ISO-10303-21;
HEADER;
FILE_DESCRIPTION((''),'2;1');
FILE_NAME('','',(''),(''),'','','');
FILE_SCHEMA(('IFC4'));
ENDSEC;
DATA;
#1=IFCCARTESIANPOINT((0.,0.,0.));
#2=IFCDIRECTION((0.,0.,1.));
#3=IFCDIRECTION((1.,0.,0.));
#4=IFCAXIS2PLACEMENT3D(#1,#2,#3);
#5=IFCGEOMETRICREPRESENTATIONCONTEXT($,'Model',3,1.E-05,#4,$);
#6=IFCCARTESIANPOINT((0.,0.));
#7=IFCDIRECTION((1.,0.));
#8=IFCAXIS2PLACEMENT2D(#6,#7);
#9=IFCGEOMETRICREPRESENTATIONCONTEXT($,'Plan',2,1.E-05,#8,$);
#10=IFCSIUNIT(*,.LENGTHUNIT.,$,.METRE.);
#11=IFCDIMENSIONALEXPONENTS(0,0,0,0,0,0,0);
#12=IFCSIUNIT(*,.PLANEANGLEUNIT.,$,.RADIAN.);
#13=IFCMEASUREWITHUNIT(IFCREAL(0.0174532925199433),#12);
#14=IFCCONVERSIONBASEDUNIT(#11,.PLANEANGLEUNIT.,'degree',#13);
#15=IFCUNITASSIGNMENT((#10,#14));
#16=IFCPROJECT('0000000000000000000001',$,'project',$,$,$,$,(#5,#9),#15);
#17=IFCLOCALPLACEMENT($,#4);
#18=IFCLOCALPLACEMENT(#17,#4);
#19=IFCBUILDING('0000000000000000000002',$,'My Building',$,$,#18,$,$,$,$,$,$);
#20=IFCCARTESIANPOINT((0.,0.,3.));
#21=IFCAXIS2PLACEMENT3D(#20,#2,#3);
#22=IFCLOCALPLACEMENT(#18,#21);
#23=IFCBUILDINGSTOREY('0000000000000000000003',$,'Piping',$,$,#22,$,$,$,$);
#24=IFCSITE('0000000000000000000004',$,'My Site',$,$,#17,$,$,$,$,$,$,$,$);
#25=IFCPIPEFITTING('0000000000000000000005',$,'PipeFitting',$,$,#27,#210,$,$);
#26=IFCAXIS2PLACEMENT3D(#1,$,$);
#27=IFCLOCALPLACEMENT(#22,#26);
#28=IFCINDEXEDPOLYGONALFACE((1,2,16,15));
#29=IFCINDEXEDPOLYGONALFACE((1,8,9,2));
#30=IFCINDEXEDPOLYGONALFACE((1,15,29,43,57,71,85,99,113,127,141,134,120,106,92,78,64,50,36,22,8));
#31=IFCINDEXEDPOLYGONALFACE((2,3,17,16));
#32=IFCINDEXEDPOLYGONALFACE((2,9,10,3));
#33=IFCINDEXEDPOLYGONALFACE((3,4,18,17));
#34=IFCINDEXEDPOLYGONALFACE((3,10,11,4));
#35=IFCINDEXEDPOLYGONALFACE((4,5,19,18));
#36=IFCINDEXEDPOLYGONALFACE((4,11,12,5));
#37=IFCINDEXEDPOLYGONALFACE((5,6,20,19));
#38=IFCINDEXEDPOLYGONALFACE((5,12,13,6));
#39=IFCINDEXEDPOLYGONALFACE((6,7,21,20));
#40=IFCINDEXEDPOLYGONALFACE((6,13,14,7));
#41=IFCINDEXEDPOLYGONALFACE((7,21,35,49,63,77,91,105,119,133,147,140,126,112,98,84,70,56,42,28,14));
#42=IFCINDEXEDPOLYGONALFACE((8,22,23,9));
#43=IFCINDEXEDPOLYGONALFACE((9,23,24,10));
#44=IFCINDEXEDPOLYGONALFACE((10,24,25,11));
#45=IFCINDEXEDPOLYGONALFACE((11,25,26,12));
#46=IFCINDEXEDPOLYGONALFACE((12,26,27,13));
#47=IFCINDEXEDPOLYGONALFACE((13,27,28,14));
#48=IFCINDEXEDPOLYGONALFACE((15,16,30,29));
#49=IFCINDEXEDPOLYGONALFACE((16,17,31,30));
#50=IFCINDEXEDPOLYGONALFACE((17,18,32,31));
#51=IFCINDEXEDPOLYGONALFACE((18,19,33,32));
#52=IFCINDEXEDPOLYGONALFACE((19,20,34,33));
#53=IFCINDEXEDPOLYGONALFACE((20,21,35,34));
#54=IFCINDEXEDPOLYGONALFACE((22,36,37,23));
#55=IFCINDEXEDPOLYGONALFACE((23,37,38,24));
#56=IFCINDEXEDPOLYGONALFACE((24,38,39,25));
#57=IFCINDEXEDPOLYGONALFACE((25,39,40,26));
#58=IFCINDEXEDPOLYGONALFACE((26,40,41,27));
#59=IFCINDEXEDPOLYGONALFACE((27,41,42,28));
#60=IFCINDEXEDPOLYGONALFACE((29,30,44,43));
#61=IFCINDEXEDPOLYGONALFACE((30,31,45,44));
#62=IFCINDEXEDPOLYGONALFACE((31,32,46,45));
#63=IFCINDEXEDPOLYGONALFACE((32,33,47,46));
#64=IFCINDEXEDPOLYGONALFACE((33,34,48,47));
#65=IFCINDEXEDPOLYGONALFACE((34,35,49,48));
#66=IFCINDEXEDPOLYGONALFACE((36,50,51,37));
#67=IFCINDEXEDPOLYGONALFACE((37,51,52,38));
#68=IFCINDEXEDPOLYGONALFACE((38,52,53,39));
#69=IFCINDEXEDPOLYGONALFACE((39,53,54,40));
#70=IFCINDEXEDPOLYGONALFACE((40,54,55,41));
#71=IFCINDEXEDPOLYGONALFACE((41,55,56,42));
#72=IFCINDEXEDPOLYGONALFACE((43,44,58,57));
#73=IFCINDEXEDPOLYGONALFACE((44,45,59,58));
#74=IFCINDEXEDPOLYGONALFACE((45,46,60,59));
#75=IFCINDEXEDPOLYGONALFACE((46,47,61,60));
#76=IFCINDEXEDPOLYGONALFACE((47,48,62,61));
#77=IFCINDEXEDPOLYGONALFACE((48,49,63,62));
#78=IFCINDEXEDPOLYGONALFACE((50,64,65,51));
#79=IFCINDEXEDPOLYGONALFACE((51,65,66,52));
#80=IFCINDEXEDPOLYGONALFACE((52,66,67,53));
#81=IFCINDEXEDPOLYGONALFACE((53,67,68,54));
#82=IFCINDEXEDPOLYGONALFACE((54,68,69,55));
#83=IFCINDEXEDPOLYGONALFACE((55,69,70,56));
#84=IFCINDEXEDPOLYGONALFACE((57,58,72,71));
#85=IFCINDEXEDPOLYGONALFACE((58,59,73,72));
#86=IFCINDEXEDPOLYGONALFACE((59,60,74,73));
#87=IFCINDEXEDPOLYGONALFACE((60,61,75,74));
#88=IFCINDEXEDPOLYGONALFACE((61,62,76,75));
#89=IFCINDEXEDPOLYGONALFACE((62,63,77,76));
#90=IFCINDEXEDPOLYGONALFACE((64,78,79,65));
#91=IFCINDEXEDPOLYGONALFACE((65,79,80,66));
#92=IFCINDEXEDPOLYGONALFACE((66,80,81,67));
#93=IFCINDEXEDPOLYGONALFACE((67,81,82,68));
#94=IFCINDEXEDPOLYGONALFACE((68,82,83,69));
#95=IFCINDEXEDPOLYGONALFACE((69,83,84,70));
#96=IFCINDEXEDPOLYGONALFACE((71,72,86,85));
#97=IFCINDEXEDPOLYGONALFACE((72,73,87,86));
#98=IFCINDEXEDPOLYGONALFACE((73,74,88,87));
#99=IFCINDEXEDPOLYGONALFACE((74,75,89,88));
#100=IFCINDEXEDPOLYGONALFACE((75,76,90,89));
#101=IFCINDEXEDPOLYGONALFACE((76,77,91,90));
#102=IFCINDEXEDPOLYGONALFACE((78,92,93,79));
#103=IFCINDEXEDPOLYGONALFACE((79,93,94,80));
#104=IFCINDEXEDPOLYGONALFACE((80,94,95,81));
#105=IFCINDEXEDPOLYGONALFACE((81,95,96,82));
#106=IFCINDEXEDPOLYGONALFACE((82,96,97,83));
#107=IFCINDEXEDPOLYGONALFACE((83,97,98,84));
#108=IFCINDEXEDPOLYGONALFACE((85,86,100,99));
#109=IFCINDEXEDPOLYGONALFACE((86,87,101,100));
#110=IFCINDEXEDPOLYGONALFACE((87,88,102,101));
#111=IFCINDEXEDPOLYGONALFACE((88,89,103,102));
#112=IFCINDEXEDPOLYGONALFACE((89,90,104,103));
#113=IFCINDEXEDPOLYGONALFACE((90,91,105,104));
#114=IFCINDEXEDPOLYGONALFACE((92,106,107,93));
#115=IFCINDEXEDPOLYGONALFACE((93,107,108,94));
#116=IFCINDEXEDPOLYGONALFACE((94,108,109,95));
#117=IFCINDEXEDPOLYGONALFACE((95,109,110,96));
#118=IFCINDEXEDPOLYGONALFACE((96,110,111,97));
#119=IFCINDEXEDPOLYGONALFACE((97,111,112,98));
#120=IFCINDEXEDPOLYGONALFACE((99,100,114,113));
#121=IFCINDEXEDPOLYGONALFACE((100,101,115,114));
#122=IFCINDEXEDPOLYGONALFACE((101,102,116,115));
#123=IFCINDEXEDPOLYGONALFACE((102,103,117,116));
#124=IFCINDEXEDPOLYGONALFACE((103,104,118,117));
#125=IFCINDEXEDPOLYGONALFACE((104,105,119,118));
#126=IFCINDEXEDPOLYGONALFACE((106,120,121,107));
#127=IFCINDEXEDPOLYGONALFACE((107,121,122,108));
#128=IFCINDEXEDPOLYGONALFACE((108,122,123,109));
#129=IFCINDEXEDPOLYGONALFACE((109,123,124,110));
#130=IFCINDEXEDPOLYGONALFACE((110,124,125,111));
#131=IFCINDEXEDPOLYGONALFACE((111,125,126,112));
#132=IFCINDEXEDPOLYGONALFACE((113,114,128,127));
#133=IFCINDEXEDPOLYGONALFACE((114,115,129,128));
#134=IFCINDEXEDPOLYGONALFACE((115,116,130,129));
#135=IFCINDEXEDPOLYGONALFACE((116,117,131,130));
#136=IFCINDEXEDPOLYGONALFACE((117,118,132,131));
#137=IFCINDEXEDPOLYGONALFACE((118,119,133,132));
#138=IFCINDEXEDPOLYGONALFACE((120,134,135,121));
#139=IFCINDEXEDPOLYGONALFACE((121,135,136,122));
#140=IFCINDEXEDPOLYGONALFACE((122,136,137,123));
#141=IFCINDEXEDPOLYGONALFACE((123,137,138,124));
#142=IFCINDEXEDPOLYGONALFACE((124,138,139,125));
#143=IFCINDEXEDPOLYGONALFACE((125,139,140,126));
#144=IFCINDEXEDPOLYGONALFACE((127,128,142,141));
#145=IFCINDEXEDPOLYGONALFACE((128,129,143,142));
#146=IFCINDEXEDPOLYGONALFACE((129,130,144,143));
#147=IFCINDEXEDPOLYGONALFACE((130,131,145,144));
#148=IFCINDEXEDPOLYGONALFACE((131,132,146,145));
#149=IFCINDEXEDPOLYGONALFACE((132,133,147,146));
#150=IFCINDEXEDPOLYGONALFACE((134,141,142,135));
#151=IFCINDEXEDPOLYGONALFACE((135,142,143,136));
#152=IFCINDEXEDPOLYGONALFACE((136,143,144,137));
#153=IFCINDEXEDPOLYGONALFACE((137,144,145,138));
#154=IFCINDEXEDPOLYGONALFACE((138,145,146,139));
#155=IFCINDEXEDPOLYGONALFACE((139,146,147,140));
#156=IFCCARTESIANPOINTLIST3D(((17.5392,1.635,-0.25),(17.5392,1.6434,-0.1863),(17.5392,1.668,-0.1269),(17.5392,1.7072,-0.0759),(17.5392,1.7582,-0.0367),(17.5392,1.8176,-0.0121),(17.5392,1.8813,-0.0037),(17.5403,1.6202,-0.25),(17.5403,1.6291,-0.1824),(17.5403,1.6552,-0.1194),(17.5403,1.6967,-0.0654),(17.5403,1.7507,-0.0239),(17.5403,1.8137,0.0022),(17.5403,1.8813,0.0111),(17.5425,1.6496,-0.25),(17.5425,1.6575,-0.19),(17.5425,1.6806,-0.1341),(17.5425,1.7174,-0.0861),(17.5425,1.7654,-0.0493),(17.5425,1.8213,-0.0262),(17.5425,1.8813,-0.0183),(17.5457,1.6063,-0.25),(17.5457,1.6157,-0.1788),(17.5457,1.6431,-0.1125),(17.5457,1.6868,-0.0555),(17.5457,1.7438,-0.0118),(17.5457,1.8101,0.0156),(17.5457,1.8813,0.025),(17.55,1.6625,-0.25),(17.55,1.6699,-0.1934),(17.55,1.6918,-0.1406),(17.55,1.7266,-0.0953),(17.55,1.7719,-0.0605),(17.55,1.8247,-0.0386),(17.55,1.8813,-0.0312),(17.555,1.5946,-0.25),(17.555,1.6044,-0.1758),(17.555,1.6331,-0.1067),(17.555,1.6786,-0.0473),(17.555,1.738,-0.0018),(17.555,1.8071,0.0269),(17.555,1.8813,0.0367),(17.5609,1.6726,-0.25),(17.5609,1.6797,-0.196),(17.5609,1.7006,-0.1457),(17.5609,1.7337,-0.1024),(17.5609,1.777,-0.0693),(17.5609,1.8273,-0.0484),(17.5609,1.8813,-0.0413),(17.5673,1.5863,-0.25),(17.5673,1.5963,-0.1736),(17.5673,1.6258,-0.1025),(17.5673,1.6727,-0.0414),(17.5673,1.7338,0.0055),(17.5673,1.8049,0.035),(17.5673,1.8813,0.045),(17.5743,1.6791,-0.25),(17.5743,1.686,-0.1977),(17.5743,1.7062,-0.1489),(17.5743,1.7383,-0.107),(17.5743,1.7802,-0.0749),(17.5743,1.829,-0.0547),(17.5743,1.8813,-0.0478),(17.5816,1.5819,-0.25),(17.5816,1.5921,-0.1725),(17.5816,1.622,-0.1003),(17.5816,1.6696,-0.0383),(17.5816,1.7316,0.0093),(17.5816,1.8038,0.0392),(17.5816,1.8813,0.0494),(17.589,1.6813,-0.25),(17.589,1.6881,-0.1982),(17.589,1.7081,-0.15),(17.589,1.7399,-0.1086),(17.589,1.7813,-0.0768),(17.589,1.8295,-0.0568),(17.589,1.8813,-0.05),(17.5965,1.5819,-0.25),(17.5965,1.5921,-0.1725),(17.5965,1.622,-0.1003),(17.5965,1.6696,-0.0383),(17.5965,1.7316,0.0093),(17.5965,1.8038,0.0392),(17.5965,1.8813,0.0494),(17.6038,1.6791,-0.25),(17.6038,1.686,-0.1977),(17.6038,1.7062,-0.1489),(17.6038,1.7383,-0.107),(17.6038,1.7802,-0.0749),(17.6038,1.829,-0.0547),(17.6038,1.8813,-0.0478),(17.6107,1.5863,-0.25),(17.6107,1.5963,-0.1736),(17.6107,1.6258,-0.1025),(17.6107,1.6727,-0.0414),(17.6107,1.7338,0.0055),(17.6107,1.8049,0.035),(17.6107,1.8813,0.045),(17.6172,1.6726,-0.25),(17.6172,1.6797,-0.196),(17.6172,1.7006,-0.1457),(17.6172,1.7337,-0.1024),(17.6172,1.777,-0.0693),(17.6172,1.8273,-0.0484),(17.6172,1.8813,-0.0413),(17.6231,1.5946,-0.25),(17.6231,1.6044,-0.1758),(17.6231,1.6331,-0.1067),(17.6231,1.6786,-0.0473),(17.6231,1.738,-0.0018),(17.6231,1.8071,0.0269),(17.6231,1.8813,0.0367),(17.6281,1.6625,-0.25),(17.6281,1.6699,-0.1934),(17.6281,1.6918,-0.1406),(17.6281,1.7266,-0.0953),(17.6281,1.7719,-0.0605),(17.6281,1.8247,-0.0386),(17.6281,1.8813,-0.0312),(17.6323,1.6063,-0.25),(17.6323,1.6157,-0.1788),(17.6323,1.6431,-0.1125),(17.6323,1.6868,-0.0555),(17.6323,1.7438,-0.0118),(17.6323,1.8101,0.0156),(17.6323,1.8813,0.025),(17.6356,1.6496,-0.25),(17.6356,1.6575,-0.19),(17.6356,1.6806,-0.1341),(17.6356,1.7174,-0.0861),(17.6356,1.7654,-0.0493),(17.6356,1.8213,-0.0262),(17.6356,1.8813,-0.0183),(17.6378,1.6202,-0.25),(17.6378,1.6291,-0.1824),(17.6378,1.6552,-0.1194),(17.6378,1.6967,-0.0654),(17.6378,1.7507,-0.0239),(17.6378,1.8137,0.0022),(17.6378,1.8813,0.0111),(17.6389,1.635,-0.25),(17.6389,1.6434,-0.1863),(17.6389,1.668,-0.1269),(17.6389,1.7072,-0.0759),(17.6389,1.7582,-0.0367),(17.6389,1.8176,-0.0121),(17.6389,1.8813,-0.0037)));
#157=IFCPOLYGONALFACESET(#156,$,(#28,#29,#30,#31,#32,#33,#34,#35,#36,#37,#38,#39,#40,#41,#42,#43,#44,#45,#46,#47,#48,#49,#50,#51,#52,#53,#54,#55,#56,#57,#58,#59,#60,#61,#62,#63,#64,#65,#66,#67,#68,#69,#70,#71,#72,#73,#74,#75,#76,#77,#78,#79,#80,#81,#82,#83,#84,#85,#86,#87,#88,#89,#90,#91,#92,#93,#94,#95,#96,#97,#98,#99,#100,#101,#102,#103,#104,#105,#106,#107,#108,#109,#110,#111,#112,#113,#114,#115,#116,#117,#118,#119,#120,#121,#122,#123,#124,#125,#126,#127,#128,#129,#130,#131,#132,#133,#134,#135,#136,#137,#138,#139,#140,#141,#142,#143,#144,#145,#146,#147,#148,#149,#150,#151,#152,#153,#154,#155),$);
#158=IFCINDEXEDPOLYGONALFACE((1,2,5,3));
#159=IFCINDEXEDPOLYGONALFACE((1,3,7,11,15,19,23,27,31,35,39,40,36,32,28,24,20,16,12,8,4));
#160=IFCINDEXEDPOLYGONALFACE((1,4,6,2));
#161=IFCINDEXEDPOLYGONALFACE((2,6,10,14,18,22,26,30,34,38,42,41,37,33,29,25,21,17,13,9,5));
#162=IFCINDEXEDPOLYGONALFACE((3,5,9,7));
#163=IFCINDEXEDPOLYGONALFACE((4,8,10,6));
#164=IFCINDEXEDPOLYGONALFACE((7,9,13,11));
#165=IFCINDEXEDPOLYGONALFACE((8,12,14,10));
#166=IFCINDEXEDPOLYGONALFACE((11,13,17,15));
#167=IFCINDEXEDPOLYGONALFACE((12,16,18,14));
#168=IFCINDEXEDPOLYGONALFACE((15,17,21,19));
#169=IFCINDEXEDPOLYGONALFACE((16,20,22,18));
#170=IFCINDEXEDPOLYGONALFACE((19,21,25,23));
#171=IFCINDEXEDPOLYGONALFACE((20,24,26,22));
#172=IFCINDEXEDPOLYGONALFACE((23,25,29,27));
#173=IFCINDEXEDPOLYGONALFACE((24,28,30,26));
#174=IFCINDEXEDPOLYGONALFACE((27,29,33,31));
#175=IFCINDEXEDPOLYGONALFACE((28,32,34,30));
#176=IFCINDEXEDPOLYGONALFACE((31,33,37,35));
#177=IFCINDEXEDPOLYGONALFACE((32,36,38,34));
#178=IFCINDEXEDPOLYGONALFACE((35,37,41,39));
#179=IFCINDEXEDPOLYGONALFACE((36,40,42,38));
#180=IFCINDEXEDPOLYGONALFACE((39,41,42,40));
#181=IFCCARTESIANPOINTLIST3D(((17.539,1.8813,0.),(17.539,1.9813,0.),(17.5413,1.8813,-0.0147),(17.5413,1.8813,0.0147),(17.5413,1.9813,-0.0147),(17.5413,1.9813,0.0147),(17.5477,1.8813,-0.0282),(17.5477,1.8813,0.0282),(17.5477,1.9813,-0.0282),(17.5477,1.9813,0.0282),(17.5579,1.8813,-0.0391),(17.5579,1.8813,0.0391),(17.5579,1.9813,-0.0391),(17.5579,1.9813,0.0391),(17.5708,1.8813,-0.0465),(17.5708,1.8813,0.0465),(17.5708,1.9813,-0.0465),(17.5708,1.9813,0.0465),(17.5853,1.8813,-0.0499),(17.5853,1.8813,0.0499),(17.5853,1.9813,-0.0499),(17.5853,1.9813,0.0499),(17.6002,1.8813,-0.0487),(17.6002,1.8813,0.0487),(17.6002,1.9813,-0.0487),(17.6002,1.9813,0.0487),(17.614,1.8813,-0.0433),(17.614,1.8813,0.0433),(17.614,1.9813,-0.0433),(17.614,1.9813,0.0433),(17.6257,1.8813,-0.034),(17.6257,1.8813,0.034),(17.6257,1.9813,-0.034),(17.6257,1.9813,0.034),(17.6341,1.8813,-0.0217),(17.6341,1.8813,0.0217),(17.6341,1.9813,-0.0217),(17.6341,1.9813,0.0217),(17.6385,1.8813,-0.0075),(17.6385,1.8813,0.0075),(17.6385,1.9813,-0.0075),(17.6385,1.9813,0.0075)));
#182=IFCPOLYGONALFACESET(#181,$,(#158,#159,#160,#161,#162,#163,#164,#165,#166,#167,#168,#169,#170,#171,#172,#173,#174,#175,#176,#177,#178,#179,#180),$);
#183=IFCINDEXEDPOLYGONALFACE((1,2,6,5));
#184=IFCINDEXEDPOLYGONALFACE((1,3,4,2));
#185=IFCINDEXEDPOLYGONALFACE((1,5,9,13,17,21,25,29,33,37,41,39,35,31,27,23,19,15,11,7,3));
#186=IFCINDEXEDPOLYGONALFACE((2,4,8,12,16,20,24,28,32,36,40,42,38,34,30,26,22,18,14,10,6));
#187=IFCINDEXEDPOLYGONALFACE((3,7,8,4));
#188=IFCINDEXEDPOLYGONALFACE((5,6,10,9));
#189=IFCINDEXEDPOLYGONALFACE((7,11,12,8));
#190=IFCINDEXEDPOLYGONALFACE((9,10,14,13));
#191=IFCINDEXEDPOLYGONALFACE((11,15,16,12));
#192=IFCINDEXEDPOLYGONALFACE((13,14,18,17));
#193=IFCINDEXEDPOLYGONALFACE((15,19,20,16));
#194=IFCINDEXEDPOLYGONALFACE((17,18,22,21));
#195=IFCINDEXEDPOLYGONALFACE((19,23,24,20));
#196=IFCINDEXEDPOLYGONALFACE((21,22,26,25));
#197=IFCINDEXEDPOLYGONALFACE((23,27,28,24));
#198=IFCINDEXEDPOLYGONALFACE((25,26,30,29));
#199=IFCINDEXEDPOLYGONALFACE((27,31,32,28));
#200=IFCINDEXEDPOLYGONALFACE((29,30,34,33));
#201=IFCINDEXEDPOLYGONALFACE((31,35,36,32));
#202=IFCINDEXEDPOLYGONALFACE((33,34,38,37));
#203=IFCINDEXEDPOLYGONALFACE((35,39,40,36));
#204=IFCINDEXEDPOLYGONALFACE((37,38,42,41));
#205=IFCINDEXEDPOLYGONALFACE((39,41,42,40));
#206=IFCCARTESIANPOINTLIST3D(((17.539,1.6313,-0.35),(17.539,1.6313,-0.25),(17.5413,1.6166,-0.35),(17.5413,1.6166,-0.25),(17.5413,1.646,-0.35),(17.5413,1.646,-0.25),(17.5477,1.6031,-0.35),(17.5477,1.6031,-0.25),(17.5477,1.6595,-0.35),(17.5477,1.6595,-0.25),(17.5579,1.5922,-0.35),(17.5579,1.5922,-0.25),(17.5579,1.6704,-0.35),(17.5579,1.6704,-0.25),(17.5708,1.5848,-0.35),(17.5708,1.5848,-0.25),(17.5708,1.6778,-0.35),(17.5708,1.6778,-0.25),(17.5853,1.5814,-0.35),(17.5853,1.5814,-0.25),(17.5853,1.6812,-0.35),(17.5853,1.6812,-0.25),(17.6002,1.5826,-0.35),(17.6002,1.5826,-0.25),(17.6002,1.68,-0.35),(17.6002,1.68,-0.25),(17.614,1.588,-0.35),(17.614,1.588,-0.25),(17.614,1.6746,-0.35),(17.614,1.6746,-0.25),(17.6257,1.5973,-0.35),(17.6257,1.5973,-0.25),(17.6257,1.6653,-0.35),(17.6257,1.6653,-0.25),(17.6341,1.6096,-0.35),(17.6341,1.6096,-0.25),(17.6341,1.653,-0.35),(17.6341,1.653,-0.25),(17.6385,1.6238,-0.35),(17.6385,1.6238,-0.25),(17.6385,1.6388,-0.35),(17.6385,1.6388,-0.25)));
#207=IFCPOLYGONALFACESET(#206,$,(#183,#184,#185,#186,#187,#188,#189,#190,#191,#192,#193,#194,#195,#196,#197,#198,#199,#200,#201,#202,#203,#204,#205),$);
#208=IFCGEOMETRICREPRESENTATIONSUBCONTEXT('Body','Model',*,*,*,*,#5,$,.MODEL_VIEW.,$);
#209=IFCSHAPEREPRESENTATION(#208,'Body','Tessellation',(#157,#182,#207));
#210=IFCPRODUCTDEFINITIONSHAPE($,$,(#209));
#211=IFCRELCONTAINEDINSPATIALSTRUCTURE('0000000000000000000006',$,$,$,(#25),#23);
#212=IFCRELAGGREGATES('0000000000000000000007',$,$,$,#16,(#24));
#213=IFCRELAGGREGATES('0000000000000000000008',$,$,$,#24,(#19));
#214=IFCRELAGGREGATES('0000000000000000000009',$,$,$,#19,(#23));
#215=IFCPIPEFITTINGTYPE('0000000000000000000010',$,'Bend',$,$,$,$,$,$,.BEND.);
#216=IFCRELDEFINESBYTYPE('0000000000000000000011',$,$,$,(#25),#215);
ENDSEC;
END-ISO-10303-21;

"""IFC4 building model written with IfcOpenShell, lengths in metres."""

from ifc_helpers import new_model, entity, si_unit, converted_unit, frame, origin_with_axes, origin_2d_with_axis, place, context, subcontext, project, spatial, circle, extrude, source, transform, mapped, type_object, type_shapes, element, save


model = new_model("IFC4")

# Units and contexts
model_context = context("Model", 3, precision=1e-05, world=origin_with_axes())
plan_context = context("Plan", 2, precision=1e-05, world=origin_2d_with_axis())
body_context = subcontext(model_context, "Body", "Model", "MODEL_VIEW")
ifc_project = project(units=[si_unit("LENGTHUNIT", "METRE"), converted_unit("PLANEANGLEUNIT", "degree", entity("IfcReal", 0.0174532925199433), si_unit("PLANEANGLEUNIT", "RADIAN"), dimensions=[0, 0, 0, 0, 0, 0, 0])], contexts=[model_context, plan_context])

# Site, building, storey
site_placement = place(None, origin_with_axes())
site = spatial("IfcSite", under=ifc_project, at=site_placement, Name="My Site")
building_placement = place(site_placement, origin_with_axes())
building = spatial("IfcBuilding", under=site, at=building_placement, Name="My Building")
storey_placement = place(building_placement, frame((0.0, 0.0, 3.0), z_axis=(0.0, 0.0, 1.0), x_axis=(1.0, 0.0, 0.0)))
storey = spatial("IfcBuildingStorey", under=building, at=storey_placement, Name="Piping")

# Pipe fitting
pipe_fitting_type = type_object("IfcPipeFittingType", Name="Bend", PredefinedType="BEND")
shared_shape = source(origin_with_axes(), body_context, "Body", "SolidModel", [
    entity("IfcSweptDiskSolid", entity("IfcIndexedPolyCurve", entity("IfcCartesianPointList3D", [[0.0, 0.0, -0.1], [0.0, -0.0732, -0.2768], [0.0, -0.25, -0.35]]), [entity("IfcArcIndex", [1, 2, 3])]), 0.05),
    extrude(circle(Radius=0.05), origin_with_axes(), (0.0, 0.0, -1.0), 0.1),
    extrude(circle(Radius=0.05), frame((0.0, -0.25, -0.35), z_axis=(0.0, -1.0, 0.0), x_axis=(1.0, 0.0, 0.0)), (0.0, 0.0, 1.0), 0.1),
])
type_shapes(pipe_fitting_type, [shared_shape])
for number, where, z_axis, x_axis, name in (
    (1, (17.589, 1.9813, 0.0), (0.0, 1.0, 0.0), (-1.0, 0.0, 0.0), "PipeFitting"),
):
    element("IfcPipeFitting", number, at=place(storey_placement, frame(where, z_axis=z_axis, x_axis=x_axis)), inside=storey, type_object=pipe_fitting_type, Name=name, context=body_context, shape_type="MappedRepresentation", body=[
        mapped(shared_shape, transform((0.0, 0.0, 0.0), x_axis=(1.0, 0.0, 0.0), y_axis=(0.0, 1.0, 0.0), z_axis=(0.0, 0.0, 1.0), scale=1.0)),
    ])

save(model, "model.ifc")
